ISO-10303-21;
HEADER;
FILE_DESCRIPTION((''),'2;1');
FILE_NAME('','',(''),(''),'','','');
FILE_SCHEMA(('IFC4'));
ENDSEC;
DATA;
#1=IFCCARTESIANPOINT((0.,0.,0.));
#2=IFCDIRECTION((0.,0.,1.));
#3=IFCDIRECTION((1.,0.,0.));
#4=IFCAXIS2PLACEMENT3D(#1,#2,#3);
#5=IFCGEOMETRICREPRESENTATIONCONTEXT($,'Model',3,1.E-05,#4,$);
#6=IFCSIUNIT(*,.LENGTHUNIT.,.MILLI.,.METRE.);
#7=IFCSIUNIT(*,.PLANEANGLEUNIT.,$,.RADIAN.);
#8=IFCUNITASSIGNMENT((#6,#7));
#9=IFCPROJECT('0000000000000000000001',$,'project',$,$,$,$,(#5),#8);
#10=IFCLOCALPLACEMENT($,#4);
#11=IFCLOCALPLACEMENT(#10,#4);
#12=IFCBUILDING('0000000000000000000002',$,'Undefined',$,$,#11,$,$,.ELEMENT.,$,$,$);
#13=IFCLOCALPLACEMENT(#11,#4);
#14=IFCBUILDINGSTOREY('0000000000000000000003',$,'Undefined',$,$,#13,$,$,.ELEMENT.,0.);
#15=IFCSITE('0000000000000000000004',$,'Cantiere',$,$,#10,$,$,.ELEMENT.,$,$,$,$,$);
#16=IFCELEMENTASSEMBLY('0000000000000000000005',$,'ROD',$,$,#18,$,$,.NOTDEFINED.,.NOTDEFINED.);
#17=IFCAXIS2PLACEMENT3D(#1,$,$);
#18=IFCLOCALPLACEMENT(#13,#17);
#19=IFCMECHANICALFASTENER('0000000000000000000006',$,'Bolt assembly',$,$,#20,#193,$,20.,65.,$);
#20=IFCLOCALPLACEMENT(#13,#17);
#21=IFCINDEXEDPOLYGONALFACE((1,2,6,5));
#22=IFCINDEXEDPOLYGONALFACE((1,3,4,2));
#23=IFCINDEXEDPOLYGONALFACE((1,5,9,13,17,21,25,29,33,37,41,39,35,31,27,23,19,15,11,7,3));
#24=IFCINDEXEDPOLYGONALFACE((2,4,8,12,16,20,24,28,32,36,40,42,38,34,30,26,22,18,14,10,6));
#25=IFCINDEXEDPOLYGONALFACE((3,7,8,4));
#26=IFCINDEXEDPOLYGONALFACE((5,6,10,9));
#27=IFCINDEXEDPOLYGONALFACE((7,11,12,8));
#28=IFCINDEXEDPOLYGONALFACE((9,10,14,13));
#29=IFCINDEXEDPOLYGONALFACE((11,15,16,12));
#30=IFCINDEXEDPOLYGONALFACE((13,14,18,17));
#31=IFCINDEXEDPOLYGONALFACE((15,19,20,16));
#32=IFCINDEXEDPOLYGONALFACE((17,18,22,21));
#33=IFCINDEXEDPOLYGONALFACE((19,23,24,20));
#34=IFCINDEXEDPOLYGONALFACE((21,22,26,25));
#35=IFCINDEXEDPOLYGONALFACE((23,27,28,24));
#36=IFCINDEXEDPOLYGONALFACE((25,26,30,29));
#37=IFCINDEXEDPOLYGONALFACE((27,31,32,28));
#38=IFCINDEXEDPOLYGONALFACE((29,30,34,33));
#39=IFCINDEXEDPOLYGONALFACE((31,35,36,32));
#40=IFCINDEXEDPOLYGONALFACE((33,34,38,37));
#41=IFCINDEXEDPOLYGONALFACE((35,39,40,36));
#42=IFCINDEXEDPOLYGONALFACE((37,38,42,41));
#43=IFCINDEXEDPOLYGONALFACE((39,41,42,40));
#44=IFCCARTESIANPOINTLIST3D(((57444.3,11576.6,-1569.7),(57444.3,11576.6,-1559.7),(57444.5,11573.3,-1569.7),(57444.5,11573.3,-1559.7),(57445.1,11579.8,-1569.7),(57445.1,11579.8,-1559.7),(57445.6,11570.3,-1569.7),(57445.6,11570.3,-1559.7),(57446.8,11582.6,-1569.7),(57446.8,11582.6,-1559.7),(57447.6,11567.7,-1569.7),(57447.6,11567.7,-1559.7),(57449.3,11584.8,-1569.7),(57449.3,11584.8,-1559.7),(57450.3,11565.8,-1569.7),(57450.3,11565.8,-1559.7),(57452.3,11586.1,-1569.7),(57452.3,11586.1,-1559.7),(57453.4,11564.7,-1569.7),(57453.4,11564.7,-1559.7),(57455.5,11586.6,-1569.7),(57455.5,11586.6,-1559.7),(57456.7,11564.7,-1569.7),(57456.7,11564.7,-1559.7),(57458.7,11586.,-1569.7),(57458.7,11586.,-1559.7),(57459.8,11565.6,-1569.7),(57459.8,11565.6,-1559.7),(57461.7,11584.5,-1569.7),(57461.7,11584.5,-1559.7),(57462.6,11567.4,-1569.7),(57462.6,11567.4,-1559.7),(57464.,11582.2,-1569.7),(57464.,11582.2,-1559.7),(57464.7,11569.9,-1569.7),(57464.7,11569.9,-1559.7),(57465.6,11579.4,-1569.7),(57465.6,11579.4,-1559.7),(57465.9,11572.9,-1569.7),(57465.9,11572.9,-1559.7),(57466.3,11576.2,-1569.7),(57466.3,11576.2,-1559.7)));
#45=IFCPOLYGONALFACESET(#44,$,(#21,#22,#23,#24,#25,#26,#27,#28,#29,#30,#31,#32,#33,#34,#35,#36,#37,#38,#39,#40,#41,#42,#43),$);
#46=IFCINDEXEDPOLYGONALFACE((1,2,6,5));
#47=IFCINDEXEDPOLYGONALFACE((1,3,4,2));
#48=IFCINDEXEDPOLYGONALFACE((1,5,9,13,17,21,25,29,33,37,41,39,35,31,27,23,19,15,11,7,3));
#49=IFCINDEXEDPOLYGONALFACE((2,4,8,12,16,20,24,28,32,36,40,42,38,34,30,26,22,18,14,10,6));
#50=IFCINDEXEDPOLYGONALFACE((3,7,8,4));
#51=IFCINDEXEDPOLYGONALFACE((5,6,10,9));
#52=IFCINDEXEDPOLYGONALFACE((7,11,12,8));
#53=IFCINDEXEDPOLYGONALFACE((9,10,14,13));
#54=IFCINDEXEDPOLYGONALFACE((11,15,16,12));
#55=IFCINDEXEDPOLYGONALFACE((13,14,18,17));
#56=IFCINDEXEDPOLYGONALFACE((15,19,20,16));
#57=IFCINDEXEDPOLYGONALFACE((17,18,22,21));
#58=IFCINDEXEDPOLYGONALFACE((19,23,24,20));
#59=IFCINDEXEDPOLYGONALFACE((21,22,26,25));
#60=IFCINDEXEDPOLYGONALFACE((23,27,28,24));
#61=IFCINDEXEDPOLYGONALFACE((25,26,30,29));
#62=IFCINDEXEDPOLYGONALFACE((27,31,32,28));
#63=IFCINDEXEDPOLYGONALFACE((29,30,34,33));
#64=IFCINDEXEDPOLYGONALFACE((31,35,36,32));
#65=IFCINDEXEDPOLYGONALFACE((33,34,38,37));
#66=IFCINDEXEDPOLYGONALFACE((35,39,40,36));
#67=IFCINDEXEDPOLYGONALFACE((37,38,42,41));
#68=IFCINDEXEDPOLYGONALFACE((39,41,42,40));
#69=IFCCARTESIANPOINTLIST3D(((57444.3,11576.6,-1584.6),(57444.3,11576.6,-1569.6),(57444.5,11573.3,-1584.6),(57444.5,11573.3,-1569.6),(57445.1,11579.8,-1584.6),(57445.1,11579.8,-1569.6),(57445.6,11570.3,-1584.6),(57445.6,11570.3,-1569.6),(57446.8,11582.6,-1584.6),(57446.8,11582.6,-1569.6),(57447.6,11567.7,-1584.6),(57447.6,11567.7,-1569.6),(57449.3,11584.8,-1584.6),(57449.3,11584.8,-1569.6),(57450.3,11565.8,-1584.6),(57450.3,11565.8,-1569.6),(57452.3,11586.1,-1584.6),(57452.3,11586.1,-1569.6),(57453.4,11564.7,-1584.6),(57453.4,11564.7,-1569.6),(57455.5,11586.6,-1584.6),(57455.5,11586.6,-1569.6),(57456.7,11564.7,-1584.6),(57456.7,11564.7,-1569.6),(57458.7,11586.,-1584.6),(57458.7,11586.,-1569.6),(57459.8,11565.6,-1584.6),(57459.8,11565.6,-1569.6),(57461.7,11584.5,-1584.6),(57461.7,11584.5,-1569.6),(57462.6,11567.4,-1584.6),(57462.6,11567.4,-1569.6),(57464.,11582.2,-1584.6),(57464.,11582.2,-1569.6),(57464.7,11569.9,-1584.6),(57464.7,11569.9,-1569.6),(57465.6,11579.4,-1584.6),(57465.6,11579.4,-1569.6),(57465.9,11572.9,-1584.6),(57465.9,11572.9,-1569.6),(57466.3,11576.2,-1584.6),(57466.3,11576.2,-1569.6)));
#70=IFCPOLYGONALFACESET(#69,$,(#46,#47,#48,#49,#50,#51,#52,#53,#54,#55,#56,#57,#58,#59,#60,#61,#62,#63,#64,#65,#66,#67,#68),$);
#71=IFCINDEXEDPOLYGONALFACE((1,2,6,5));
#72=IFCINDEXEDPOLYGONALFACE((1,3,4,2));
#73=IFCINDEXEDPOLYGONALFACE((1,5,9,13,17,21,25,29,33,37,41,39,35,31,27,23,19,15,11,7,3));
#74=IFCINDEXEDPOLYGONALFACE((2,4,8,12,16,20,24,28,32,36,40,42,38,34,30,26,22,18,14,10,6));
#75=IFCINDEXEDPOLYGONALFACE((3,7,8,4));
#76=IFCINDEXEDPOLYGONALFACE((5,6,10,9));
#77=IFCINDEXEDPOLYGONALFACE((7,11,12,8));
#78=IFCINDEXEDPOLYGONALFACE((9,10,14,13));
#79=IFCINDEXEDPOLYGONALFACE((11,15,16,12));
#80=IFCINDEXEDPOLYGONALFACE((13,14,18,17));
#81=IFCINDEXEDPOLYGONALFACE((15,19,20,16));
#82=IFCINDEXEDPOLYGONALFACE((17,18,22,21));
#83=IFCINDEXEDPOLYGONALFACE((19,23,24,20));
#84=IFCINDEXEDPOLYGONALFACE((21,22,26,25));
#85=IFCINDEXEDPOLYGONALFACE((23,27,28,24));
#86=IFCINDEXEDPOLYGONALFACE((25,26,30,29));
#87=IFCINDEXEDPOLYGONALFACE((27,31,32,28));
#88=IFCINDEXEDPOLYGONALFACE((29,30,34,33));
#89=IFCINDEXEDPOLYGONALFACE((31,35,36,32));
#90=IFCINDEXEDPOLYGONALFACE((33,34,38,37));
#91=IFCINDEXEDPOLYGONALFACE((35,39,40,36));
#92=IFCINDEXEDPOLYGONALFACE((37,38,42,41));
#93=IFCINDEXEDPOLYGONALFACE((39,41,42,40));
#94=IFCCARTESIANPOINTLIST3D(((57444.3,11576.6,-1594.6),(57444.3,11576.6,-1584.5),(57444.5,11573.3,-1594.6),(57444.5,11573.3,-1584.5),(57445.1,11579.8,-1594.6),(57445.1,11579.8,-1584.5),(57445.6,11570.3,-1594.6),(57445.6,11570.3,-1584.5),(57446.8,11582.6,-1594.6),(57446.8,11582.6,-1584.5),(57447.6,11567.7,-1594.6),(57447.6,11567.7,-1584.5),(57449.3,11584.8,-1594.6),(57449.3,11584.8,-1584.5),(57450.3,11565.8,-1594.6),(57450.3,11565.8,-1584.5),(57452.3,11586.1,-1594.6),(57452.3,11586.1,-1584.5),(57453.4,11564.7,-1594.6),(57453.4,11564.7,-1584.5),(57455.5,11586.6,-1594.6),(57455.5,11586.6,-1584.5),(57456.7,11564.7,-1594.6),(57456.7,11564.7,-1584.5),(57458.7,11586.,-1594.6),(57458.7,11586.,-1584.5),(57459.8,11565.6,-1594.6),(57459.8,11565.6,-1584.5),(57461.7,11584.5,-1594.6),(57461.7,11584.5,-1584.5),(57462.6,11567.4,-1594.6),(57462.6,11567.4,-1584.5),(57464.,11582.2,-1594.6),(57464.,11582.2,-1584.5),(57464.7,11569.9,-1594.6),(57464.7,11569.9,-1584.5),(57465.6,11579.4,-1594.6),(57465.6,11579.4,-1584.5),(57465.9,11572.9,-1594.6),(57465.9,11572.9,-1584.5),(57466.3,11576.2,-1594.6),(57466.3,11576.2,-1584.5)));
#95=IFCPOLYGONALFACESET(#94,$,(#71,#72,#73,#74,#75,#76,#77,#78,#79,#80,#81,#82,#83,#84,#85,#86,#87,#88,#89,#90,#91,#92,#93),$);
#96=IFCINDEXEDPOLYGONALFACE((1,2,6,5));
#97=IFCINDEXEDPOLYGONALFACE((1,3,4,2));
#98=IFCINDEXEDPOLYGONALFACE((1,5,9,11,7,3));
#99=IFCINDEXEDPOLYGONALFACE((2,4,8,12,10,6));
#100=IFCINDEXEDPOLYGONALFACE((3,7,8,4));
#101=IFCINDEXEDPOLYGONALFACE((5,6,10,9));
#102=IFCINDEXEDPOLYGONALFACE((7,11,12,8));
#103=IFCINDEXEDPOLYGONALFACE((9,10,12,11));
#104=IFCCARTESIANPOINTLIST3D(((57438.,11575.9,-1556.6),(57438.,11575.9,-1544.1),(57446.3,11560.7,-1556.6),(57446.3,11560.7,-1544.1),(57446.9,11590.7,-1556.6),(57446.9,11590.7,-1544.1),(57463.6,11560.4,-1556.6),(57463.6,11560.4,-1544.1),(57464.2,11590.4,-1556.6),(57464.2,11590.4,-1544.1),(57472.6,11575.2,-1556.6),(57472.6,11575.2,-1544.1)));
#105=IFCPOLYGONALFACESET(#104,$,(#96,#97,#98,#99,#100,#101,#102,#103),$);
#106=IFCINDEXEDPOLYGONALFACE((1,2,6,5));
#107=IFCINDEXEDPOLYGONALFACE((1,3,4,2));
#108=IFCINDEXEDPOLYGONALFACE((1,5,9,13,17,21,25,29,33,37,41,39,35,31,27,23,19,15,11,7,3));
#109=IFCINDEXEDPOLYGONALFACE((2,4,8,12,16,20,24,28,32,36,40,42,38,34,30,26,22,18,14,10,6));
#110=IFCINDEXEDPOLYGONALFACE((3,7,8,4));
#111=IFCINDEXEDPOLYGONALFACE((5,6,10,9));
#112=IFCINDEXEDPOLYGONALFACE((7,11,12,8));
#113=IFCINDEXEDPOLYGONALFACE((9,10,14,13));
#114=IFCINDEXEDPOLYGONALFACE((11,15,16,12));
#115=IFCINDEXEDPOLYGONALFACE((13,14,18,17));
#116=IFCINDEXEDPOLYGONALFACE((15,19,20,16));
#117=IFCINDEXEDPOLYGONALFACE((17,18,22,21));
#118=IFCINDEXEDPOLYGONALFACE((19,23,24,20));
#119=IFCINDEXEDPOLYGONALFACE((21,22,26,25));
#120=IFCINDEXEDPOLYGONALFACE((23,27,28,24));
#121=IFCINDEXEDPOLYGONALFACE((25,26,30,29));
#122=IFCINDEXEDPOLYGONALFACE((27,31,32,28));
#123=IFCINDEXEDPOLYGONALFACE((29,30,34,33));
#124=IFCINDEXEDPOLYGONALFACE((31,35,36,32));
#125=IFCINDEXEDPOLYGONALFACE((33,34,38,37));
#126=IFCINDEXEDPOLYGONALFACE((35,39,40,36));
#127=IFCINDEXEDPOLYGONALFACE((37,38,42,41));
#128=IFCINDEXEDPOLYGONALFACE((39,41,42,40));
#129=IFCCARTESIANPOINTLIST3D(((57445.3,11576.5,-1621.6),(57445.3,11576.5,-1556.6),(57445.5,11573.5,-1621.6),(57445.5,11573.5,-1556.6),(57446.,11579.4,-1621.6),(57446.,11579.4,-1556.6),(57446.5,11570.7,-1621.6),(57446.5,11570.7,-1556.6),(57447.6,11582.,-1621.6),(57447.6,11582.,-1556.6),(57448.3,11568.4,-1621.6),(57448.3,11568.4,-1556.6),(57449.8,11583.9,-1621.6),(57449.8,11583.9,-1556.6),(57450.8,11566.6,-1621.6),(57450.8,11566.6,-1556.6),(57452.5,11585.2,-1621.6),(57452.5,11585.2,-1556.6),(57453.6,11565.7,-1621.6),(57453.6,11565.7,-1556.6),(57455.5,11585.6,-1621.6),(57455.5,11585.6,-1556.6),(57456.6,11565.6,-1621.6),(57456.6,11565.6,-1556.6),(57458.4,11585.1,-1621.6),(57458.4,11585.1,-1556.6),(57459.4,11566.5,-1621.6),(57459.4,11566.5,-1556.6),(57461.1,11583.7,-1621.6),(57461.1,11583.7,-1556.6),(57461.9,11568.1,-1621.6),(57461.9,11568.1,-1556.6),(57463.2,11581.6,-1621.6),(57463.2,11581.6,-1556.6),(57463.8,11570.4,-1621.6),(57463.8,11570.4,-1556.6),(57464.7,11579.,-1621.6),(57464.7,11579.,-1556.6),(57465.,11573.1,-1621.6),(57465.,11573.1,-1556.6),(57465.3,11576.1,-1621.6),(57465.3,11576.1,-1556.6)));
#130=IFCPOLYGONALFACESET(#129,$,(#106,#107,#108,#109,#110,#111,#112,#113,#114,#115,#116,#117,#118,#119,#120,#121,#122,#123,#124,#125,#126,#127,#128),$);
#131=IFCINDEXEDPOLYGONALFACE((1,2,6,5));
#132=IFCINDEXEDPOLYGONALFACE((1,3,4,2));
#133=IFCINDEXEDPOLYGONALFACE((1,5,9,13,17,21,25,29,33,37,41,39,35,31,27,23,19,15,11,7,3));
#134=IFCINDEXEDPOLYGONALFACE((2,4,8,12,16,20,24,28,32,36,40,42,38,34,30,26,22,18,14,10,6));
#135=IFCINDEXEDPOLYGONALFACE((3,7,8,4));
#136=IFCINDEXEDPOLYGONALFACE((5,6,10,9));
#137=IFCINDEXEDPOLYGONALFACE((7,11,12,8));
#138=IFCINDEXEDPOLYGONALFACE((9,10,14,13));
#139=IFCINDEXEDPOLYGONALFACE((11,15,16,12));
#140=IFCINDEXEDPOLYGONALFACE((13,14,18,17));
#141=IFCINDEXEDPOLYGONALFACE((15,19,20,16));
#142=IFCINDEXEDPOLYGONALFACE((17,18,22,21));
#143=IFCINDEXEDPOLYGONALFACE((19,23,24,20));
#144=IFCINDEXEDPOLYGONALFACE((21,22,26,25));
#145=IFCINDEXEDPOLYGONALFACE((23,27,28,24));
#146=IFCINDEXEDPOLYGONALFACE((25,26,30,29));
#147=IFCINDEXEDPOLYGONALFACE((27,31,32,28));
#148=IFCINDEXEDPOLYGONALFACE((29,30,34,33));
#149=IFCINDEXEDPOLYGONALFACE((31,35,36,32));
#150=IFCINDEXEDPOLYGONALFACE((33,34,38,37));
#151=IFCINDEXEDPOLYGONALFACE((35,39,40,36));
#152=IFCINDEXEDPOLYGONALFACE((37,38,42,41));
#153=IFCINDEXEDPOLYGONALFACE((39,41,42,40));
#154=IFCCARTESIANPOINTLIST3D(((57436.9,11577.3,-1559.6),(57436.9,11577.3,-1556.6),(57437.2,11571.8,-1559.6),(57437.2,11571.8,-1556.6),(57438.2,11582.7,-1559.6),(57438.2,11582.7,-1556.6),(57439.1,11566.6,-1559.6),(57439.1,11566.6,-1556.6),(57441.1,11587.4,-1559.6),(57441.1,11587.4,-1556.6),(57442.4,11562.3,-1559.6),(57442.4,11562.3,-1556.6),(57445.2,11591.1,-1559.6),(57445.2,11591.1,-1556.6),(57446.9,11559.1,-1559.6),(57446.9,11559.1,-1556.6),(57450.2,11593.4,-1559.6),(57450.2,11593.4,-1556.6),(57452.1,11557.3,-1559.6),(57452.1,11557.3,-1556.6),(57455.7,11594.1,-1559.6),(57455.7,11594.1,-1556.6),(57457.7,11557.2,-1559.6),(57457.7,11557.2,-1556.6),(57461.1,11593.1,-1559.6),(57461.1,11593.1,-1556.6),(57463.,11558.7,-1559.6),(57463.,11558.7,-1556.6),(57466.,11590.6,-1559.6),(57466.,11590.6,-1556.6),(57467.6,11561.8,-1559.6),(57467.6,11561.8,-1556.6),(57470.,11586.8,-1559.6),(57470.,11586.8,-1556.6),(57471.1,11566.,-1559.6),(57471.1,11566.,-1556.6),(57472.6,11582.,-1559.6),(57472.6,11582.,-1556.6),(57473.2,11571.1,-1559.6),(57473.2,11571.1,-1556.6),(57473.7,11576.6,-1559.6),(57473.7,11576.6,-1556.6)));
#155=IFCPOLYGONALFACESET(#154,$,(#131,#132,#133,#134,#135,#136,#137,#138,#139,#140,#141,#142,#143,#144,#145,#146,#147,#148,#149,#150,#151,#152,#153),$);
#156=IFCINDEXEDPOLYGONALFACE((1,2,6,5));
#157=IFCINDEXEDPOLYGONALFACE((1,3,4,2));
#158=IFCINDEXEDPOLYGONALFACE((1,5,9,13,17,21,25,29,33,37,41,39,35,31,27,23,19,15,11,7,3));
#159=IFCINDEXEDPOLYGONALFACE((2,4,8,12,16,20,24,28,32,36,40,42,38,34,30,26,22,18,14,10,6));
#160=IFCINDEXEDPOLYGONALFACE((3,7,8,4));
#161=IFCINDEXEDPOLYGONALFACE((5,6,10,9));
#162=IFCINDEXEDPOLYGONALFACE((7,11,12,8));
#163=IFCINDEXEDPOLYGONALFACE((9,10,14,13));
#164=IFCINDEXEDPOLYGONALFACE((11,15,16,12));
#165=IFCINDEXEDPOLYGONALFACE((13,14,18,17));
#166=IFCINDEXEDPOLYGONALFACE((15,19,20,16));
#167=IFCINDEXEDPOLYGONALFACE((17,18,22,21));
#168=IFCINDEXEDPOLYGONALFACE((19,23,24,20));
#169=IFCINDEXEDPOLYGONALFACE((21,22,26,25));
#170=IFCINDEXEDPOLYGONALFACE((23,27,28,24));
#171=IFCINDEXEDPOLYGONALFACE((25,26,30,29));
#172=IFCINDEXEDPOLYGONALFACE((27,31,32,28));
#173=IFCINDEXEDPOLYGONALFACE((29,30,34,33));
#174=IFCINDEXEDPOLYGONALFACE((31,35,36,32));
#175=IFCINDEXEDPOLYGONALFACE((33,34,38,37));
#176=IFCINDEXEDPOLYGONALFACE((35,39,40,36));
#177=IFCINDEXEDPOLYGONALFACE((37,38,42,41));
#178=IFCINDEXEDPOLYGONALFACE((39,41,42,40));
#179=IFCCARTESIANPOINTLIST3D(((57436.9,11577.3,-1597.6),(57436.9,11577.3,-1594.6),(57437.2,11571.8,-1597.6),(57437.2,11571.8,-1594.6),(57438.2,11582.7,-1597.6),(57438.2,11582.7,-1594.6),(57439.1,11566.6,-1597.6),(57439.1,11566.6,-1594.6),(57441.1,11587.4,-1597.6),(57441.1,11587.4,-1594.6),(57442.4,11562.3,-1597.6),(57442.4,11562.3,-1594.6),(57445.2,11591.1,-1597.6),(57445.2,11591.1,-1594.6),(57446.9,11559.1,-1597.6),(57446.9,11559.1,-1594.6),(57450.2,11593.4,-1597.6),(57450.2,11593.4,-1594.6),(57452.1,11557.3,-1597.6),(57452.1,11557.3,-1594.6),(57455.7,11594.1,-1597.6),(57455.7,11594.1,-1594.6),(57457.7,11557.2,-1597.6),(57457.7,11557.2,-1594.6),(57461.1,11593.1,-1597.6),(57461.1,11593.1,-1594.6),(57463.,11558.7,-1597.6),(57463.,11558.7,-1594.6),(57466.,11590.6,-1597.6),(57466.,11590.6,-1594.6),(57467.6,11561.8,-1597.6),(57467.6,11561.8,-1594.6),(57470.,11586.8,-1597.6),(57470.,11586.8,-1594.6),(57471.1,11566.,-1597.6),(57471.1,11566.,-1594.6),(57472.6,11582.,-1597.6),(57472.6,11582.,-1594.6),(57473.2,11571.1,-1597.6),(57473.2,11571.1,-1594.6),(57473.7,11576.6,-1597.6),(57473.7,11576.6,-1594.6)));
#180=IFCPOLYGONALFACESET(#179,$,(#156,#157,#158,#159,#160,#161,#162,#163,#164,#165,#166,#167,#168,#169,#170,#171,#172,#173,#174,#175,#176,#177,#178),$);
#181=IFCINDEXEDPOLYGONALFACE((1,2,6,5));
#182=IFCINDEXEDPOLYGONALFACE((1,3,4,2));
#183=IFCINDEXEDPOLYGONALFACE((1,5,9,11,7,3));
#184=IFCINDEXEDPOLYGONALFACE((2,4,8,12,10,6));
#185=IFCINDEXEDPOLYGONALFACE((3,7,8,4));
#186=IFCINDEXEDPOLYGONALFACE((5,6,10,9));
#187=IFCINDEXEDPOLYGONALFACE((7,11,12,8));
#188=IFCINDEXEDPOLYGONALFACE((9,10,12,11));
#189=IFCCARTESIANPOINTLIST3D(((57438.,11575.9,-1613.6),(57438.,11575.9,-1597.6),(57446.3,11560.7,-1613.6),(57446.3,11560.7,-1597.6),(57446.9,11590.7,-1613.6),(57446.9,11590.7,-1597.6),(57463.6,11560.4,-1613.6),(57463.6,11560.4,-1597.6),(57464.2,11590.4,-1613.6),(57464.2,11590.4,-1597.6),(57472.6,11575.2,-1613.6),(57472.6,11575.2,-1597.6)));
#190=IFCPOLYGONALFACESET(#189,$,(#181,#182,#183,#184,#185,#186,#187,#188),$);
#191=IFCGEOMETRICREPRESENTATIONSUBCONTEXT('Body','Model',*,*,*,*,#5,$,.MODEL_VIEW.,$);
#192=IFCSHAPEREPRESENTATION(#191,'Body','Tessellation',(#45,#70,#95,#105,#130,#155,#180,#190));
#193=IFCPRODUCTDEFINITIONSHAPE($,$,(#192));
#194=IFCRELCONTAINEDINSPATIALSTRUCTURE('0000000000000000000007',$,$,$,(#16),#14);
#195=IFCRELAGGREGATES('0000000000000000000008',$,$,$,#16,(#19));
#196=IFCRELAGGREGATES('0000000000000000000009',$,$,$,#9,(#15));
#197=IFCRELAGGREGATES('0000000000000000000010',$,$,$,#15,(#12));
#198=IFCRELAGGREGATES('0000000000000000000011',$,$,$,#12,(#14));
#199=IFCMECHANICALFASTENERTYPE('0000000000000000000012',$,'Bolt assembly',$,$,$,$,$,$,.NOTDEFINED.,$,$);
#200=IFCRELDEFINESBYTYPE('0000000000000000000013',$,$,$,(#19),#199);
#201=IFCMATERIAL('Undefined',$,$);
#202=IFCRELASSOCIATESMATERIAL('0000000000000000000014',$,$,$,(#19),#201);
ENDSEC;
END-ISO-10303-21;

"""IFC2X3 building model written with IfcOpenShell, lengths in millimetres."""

from ifc_helpers import new_model, si_unit, frame, origin_with_axes, origin_2d_with_axis, place, context, subcontext, project, spatial, polyline, circle, outline, extrude, source, transform, mapped, material, type_object, element, aggregate, save


model = new_model("IFC2X3")

# Units and contexts
model_context = context("Model", 3, precision=1e-05, world=origin_with_axes())
body_context = subcontext(model_context, "Body", "Model", "MODEL_VIEW")
ifc_project = project(units=[si_unit("LENGTHUNIT", "METRE", prefix="MILLI"), si_unit("PLANEANGLEUNIT", "RADIAN")], contexts=[model_context])

# Site, building, storey
site_placement = place(None, origin_with_axes())
site = spatial("IfcSite", under=ifc_project, at=site_placement, Name="Cantiere", CompositionType="ELEMENT")
building_placement = place(site_placement, origin_with_axes())
building = spatial("IfcBuilding", under=site, at=building_placement, Name="Undefined", CompositionType="ELEMENT")
storey_placement = place(building_placement, origin_with_axes())
storey = spatial("IfcBuildingStorey", under=building, at=storey_placement, Name="Undefined", CompositionType="ELEMENT", Elevation=0.0)

# Element assembly
assembly_1_placement = place(storey_placement, origin_with_axes())
assembly_1 = element("IfcElementAssembly", 1, at=assembly_1_placement, inside=storey, Name="ROD", AssemblyPlace="NOTDEFINED", PredefinedType="NOTDEFINED")

# Mechanical fastener
ifc_material_1 = material(Name="Undefined")
mechanical_fastener_type = type_object("IfcMechanicalFastenerType", Name="Bolt assembly")
shared_shape_1 = source(origin_with_axes(), body_context, "Body", "SweptSolid", [
    extrude(circle(Radius=11.0, at=origin_2d_with_axis()), frame((0.0, 0.1, 0.0), z_axis=(0.0, 1.0, 0.0), x_axis=(1.0, 0.0, 0.0)), (0.0, 0.0, 1.0), 10.0),
    extrude(circle(Radius=11.0, at=origin_2d_with_axis()), frame((0.0, 10.0, 0.0), z_axis=(0.0, 1.0, 0.0), x_axis=(1.0, 0.0, 0.0)), (0.0, 0.0, 1.0), 15.0),
    extrude(circle(Radius=11.0, at=origin_2d_with_axis()), frame((0.0, 24.9, 0.0), z_axis=(0.0, 1.0, 0.0), x_axis=(1.0, 0.0, 0.0)), (0.0, 0.0, 1.0), 10.1),
    extrude(outline(polyline([(15.0, -8.7), (15.0, 8.7), (0.0, 17.3), (-15.0, 8.7), (-15.0, -8.7), (0.0, -17.3), (15.0, -8.7)])), frame((0.0, -15.5, 0.0), z_axis=(0.0, 1.0, 0.0), x_axis=(1.0, 0.0, 0.0)), (0.0, 0.0, 1.0), 12.5),
    extrude(circle(Radius=10.0, at=origin_2d_with_axis()), frame((0.0, -3.0, 0.0), z_axis=(0.0, 1.0, 0.0), x_axis=(1.0, 0.0, 0.0)), (0.0, 0.0, 1.0), 65.0),
    extrude(circle(Radius=18.5, at=origin_2d_with_axis()), frame((0.0, -3.0, 0.0), z_axis=(0.0, 1.0, 0.0), x_axis=(1.0, 0.0, 0.0)), (0.0, 0.0, 1.0), 3.0),
    extrude(circle(Radius=18.5, at=origin_2d_with_axis()), frame((0.0, 35.0, 0.0), z_axis=(0.0, 1.0, 0.0), x_axis=(1.0, 0.0, 0.0)), (0.0, 0.0, 1.0), 3.0),
    extrude(outline(polyline([(15.0, -8.7), (15.0, 8.7), (0.0, 17.3), (-15.0, 8.7), (-15.0, -8.7), (0.0, -17.3), (15.0, -8.7)])), frame((0.0, 38.0, 0.0), z_axis=(0.0, 1.0, 0.0), x_axis=(1.0, 0.0, 0.0)), (0.0, 0.0, 1.0), 16.0),
])
mechanical_fastener_1_placement = place(assembly_1_placement, frame((57455.3, 11575.6, -1559.6), z_axis=(-0.99979, 0.02048, 0.0), x_axis=(0.02048, 0.99979, 0.0)))
mechanical_fastener_1 = element("IfcMechanicalFastener", 2, at=mechanical_fastener_1_placement, type_object=mechanical_fastener_type, material=ifc_material_1, Name="Bolt assembly", NominalDiameter=20.0, NominalLength=65.0, context=body_context, shape_type="MappedRepresentation", body=[
    mapped(shared_shape_1, transform((0.0, 0.0, 0.0))),
])
aggregate(assembly_1, [mechanical_fastener_1])

save(model, "model.ifc")
